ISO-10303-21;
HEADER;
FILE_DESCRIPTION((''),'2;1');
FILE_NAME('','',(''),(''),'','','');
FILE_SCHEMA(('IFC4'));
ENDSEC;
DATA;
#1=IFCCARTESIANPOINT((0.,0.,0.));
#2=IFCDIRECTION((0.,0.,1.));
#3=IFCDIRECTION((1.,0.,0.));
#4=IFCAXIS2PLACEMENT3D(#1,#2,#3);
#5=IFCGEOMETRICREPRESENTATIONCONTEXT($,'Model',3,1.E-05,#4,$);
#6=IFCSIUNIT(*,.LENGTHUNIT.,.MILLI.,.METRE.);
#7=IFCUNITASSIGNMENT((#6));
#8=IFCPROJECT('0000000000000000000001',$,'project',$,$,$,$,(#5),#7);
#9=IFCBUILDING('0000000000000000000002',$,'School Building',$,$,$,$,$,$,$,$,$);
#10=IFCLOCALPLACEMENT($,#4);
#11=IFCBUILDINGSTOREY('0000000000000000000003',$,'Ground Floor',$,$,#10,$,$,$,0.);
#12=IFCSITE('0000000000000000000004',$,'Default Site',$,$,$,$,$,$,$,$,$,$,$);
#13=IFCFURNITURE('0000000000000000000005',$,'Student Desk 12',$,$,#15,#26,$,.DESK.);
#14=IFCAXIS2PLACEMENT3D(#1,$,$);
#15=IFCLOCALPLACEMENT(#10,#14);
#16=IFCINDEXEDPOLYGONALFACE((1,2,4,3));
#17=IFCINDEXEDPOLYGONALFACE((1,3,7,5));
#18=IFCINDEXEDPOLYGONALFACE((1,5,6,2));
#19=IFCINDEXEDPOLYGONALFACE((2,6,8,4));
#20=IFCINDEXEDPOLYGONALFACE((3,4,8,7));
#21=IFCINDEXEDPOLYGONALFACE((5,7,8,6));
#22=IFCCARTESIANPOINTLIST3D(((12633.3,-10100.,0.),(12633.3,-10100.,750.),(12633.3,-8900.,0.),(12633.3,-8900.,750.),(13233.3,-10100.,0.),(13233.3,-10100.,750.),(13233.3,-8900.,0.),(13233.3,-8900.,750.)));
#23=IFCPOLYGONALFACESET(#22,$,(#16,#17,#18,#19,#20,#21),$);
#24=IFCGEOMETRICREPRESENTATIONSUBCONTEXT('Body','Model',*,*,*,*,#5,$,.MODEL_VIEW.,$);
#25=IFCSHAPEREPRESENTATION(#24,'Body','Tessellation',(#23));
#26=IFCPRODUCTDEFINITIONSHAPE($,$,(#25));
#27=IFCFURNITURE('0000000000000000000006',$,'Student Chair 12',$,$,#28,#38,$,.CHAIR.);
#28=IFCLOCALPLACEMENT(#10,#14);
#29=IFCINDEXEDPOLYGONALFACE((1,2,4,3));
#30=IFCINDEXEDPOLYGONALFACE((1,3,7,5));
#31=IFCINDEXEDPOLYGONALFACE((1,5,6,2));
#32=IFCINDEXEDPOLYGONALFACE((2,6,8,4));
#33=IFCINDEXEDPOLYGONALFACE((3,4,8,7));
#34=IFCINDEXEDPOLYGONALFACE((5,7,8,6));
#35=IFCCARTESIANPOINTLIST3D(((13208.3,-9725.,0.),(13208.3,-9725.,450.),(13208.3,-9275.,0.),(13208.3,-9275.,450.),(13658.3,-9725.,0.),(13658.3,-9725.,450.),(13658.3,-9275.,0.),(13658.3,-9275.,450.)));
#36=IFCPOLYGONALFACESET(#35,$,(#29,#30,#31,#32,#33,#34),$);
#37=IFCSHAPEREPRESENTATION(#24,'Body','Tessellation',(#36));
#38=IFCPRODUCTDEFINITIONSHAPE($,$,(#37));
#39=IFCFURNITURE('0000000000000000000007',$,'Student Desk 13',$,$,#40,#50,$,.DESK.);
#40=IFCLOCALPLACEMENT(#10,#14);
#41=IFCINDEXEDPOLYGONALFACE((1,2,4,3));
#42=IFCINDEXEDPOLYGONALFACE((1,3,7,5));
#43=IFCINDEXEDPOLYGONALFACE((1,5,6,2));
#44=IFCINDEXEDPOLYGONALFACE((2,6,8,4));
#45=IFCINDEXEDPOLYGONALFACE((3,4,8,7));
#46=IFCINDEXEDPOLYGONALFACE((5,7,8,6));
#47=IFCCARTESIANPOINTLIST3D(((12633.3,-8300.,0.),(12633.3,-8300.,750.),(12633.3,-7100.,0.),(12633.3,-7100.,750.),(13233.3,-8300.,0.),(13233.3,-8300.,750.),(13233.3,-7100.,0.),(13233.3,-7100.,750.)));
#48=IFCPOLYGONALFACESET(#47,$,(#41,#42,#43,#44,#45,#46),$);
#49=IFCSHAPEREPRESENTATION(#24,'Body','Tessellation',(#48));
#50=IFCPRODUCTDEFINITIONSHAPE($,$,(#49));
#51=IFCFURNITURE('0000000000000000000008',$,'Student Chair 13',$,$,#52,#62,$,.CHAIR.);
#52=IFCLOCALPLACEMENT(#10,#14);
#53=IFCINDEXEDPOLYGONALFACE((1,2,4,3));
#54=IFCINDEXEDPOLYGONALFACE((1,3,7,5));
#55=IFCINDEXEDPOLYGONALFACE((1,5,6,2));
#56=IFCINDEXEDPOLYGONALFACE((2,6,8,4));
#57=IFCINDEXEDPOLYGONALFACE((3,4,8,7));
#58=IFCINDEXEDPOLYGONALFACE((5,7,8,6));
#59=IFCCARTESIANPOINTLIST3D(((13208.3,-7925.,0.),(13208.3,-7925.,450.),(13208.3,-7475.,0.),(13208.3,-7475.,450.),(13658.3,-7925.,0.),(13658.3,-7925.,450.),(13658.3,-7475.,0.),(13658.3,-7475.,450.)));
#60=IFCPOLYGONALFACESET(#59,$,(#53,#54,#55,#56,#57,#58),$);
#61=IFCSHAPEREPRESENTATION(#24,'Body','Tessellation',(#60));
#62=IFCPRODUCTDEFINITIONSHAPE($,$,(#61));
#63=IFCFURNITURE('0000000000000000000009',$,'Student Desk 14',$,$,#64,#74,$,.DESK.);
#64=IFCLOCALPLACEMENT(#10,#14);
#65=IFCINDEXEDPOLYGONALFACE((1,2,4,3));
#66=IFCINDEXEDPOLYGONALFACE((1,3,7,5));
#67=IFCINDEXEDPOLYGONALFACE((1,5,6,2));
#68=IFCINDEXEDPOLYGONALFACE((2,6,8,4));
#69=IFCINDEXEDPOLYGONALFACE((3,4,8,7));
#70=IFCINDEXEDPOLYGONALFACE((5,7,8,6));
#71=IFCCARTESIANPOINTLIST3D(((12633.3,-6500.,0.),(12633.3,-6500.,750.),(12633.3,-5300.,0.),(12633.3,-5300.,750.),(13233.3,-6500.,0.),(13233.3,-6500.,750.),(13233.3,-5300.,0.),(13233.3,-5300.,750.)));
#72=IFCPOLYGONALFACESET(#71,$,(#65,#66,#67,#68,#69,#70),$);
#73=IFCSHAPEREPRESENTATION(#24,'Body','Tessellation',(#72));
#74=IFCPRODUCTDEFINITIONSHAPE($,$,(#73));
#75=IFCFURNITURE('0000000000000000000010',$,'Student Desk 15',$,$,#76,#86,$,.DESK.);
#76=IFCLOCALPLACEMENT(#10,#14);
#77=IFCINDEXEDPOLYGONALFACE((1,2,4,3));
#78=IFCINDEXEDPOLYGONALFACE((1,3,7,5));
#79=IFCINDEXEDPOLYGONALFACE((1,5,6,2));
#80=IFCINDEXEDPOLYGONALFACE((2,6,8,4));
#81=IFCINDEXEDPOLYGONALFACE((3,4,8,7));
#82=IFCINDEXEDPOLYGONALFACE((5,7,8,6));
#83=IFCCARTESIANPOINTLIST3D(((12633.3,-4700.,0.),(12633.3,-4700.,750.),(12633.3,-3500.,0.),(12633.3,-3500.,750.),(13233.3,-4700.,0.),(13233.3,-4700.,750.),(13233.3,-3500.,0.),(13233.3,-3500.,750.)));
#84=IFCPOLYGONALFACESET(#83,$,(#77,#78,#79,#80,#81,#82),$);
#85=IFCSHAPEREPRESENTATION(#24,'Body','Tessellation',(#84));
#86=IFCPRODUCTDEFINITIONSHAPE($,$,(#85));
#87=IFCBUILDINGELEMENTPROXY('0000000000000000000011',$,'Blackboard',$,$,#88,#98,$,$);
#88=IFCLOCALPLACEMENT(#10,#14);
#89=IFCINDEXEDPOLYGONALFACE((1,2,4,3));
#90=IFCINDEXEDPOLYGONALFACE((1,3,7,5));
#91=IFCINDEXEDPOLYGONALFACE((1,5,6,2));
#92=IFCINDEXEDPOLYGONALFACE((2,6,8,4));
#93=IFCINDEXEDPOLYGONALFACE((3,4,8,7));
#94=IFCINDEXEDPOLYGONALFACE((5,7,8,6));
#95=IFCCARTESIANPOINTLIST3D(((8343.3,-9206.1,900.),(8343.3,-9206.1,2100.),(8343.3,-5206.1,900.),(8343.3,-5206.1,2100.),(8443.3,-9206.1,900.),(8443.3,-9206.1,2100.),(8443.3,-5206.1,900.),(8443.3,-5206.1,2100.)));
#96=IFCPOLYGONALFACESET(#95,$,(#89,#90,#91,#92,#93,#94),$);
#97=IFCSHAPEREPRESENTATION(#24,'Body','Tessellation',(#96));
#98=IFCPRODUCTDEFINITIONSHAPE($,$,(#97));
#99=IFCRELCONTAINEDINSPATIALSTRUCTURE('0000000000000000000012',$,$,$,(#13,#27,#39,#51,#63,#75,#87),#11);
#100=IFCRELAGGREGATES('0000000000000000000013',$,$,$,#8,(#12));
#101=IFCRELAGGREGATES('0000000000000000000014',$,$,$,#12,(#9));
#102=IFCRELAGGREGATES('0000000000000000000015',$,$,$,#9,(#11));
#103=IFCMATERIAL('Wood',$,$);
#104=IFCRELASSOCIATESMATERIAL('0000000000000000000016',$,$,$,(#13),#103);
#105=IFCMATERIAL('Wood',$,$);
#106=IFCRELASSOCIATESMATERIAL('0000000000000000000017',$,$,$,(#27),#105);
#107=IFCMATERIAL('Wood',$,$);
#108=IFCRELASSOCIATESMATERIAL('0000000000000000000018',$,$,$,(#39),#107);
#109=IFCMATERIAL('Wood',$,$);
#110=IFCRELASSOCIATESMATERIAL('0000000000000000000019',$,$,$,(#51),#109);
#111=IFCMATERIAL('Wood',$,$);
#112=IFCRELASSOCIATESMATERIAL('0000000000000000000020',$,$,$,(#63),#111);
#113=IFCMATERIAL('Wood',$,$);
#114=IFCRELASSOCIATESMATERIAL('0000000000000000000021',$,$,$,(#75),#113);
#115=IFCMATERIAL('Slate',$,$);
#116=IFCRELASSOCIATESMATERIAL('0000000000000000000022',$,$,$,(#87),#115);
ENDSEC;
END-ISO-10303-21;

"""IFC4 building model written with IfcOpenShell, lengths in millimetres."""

from ifc_helpers import new_model, si_unit, frame, origin_with_axes, origin_2d, place, context, subcontext, project, spatial, rectangle, extrude, material, element, save


model = new_model("IFC4")

# Units and contexts
model_context = context("Model", 3, precision=1e-05, world=origin_with_axes())
body_context = subcontext(model_context, "Body", "Model", "MODEL_VIEW")
ifc_project = project(units=[si_unit("LENGTHUNIT", "METRE", prefix="MILLI")], contexts=[model_context])

# Site, building, storey
site = spatial("IfcSite", under=ifc_project, Name="Default Site")
building = spatial("IfcBuilding", under=site, Name="School Building")
storey_placement = place(None, origin_with_axes())
storey = spatial("IfcBuildingStorey", under=building, at=storey_placement, Name="Ground Floor", Elevation=0.0)

# Furniture
ifc_material_1 = material(Name="Wood")
furniture_1_placement = place(storey_placement, frame((12933.3, -9500.0, 0.0), z_axis=(0.0, 0.0, 1.0), x_axis=(0.0, 1.0, 0.0)))
element("IfcFurniture", 1, at=furniture_1_placement, inside=storey, material=ifc_material_1, Name="Student Desk 12", PredefinedType="DESK", context=body_context, shape_type="SweptSolid", body=[
    extrude(rectangle(XDim=1200.0, YDim=600.0, at=origin_2d()), origin_with_axes(), (0.0, 0.0, 1.0), 750.0),
])
ifc_material_2 = material(Name="Wood")
furniture_2_placement = place(storey_placement, frame((13433.3, -9500.0, 0.0), z_axis=(0.0, 0.0, 1.0), x_axis=(1.0, 0.0, 0.0)))
element("IfcFurniture", 2, at=furniture_2_placement, inside=storey, material=ifc_material_2, Name="Student Chair 12", PredefinedType="CHAIR", context=body_context, shape_type="SweptSolid", body=[
    extrude(rectangle(XDim=450.0, YDim=450.0, at=origin_2d()), origin_with_axes(), (0.0, 0.0, 1.0), 450.0),
])
ifc_material_3 = material(Name="Wood")
furniture_3_placement = place(storey_placement, frame((12933.3, -7700.0, 0.0), z_axis=(0.0, 0.0, 1.0), x_axis=(0.0, 1.0, 0.0)))
element("IfcFurniture", 3, at=furniture_3_placement, inside=storey, material=ifc_material_3, Name="Student Desk 13", PredefinedType="DESK", context=body_context, shape_type="SweptSolid", body=[
    extrude(rectangle(XDim=1200.0, YDim=600.0, at=origin_2d()), origin_with_axes(), (0.0, 0.0, 1.0), 750.0),
])
ifc_material_4 = material(Name="Wood")
furniture_4_placement = place(storey_placement, frame((13433.3, -7700.0, 0.0), z_axis=(0.0, 0.0, 1.0), x_axis=(1.0, 0.0, 0.0)))
element("IfcFurniture", 4, at=furniture_4_placement, inside=storey, material=ifc_material_4, Name="Student Chair 13", PredefinedType="CHAIR", context=body_context, shape_type="SweptSolid", body=[
    extrude(rectangle(XDim=450.0, YDim=450.0, at=origin_2d()), origin_with_axes(), (0.0, 0.0, 1.0), 450.0),
])
ifc_material_5 = material(Name="Wood")
furniture_5_placement = place(storey_placement, frame((12933.3, -5900.0, 0.0), z_axis=(0.0, 0.0, 1.0), x_axis=(0.0, 1.0, 0.0)))
element("IfcFurniture", 5, at=furniture_5_placement, inside=storey, material=ifc_material_5, Name="Student Desk 14", PredefinedType="DESK", context=body_context, shape_type="SweptSolid", body=[
    extrude(rectangle(XDim=1200.0, YDim=600.0, at=origin_2d()), origin_with_axes(), (0.0, 0.0, 1.0), 750.0),
])
ifc_material_6 = material(Name="Wood")
furniture_6_placement = place(storey_placement, frame((12933.3, -4100.0, 0.0), z_axis=(0.0, 0.0, 1.0), x_axis=(0.0, 1.0, 0.0)))
element("IfcFurniture", 6, at=furniture_6_placement, inside=storey, material=ifc_material_6, Name="Student Desk 15", PredefinedType="DESK", context=body_context, shape_type="SweptSolid", body=[
    extrude(rectangle(XDim=1200.0, YDim=600.0, at=origin_2d()), origin_with_axes(), (0.0, 0.0, 1.0), 750.0),
])

# Building element proxy
ifc_material_7 = material(Name="Slate")
proxy_placement = place(storey_placement, frame((8393.3, -7206.1, 900.0), z_axis=(0.0, 0.0, 1.0), x_axis=(1.0, 0.0, 0.0)))
element("IfcBuildingElementProxy", 7, at=proxy_placement, inside=storey, material=ifc_material_7, Name="Blackboard", context=body_context, shape_type="SweptSolid", body=[
    extrude(rectangle(XDim=100.0, YDim=4000.0, at=origin_2d()), origin_with_axes(), (0.0, 0.0, 1.0), 1200.0),
])

save(model, "model.ifc")
